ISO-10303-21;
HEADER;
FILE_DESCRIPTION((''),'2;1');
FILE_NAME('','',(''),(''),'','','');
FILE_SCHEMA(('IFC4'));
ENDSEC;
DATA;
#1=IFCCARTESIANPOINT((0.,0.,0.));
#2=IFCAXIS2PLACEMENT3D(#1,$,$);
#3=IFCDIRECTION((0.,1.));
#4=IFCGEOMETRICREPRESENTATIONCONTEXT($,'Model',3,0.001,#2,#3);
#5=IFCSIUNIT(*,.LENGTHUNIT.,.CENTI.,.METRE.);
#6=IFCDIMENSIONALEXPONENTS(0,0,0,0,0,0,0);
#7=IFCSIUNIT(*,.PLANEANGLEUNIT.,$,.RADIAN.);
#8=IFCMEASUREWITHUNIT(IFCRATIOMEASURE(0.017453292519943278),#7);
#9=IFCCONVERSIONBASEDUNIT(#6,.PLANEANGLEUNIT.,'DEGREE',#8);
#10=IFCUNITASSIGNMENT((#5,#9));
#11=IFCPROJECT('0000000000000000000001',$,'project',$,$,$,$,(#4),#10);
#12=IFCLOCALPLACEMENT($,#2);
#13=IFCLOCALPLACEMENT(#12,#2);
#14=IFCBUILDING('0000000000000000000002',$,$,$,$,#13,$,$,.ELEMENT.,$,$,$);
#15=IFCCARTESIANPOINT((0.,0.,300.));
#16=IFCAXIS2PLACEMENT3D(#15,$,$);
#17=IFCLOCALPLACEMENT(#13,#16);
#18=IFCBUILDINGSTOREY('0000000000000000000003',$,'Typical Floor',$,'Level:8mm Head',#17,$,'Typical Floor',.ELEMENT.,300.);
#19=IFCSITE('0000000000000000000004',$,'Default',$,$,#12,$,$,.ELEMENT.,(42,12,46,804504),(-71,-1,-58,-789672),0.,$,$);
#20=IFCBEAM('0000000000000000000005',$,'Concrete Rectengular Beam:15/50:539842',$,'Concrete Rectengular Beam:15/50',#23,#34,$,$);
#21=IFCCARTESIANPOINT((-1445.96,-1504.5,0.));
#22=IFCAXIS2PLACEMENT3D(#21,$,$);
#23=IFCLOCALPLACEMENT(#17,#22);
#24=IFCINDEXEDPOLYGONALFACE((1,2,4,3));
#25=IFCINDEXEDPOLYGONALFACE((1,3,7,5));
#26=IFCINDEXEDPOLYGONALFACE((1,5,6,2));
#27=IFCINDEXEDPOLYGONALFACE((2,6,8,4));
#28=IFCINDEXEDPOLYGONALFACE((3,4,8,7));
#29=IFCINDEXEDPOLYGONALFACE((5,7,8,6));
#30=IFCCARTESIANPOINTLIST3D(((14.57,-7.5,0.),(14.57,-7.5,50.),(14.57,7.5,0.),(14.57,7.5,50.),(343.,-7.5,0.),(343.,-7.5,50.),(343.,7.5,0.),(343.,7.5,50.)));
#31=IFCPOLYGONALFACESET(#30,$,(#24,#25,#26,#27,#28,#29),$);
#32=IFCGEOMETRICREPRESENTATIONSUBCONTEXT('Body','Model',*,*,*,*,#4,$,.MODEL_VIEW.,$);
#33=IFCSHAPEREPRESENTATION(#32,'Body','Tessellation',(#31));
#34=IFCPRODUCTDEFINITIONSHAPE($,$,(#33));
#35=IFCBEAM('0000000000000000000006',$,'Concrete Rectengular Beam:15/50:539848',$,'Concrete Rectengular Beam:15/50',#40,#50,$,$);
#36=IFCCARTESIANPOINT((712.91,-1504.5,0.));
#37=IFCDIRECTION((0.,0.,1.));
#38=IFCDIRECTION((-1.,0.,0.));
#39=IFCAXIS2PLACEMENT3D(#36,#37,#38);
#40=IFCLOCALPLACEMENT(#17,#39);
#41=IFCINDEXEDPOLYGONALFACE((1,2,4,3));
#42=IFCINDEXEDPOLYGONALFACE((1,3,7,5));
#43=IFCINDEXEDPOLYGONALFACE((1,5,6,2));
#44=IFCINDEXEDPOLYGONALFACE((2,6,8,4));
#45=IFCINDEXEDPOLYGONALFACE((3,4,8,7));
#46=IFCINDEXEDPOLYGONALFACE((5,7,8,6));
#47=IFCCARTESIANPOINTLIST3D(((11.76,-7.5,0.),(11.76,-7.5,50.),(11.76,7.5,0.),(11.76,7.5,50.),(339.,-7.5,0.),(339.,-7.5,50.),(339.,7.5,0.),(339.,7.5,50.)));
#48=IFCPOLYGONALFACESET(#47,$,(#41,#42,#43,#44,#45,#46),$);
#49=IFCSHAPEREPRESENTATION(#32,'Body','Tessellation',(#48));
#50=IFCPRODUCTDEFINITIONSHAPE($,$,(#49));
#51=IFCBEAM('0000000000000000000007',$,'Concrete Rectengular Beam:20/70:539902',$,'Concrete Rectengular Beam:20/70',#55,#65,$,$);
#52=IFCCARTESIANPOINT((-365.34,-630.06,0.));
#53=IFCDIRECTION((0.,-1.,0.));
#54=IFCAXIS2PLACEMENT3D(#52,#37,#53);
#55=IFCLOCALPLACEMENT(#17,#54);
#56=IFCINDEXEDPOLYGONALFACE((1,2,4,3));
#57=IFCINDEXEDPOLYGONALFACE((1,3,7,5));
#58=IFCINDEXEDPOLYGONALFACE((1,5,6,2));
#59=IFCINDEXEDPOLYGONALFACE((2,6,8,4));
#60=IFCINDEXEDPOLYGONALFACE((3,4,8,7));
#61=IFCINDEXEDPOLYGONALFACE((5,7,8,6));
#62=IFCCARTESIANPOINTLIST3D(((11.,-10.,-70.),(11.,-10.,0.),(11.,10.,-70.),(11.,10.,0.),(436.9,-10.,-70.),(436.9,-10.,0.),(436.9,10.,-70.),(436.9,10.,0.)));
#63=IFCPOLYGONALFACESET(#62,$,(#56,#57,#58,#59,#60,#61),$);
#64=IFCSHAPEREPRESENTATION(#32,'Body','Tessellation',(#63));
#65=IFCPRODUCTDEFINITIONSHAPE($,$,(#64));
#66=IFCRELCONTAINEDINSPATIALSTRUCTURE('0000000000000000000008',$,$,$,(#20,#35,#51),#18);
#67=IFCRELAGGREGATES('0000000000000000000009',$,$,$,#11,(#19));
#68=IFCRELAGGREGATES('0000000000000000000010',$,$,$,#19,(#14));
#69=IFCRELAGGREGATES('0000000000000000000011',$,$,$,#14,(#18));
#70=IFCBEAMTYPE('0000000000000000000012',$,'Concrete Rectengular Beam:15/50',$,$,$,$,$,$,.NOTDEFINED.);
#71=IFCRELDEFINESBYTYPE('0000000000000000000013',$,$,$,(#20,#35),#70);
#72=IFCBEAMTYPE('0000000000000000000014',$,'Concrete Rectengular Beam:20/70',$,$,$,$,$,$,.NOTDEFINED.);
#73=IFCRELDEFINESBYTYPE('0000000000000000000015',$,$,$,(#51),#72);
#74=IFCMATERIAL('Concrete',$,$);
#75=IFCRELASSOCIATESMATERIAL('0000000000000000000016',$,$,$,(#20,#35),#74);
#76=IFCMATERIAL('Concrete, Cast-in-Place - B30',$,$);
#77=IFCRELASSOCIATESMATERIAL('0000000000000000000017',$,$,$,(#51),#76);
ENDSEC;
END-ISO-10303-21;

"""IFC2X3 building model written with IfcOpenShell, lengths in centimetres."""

from ifc_helpers import new_model, entity, si_unit, converted_unit, direction, frame, frame_2d, origin, place, context, subcontext, project, spatial, rectangle, extrude, material, type_object, element, save


model = new_model("IFC2X3")

# Units and contexts
model_context = context("Model", 3, precision=0.001, world=origin(), true_north=direction((0.0, 1.0)))
body_context = subcontext(model_context, "Body", "Model", "MODEL_VIEW")
ifc_project = project(units=[si_unit("LENGTHUNIT", "METRE", prefix="CENTI"), converted_unit("PLANEANGLEUNIT", "DEGREE", entity("IfcRatioMeasure", 0.017453292519943278), si_unit("PLANEANGLEUNIT", "RADIAN"), dimensions=[0, 0, 0, 0, 0, 0, 0])], contexts=[model_context])

# Site, building, storey
site_placement = place(None, origin())
site = spatial("IfcSite", under=ifc_project, at=site_placement, Name="Default", CompositionType="ELEMENT", RefLatitude=(42, 12, 46, 804504), RefLongitude=(-71, -1, -58, -789672), RefElevation=0.0)
building_placement = place(site_placement, origin())
building = spatial("IfcBuilding", under=site, at=building_placement, CompositionType="ELEMENT")
storey_placement = place(building_placement, frame((0.0, 0.0, 300.0)))
storey = spatial("IfcBuildingStorey", under=building, at=storey_placement, Name="Typical Floor", ObjectType="Level:8mm Head", LongName="Typical Floor", CompositionType="ELEMENT", Elevation=300.0)

# Beams
ifc_material_1 = material(Name="Concrete")
beam_type_1 = type_object("IfcBeamType", Name="Concrete Rectengular Beam:15/50", PredefinedType="NOTDEFINED")
beam_1_placement = place(storey_placement, frame((-1445.96, -1504.5, 0.0)))
element("IfcBeam", 1, at=beam_1_placement, inside=storey, type_object=beam_type_1, material=ifc_material_1, Name="Concrete Rectengular Beam:15/50:539842", ObjectType="Concrete Rectengular Beam:15/50", context=body_context, shape_type="SweptSolid", body=[
    extrude(rectangle(XDim=50.0, YDim=15.0, at=frame_2d((0.0, 0.0), x_axis=(1.0, 0.0))), frame((14.57, 0.0, 25.0), z_axis=(1.0, 0.0, 0.0), x_axis=(0.0, 0.0, -1.0)), (0.0, 0.0, 1.0), 328.43),
])
beam_2_placement = place(storey_placement, frame((712.91, -1504.5, 0.0), z_axis=(0.0, 0.0, 1.0), x_axis=(-1.0, 0.0, 0.0)))
element("IfcBeam", 2, at=beam_2_placement, inside=storey, type_object=beam_type_1, material=ifc_material_1, Name="Concrete Rectengular Beam:15/50:539848", ObjectType="Concrete Rectengular Beam:15/50", context=body_context, shape_type="SweptSolid", body=[
    extrude(rectangle(XDim=50.0, YDim=15.0, at=frame_2d((0.0, 0.0), x_axis=(1.0, 0.0))), frame((11.76, 0.0, 25.0), z_axis=(1.0, 0.0, 0.0), x_axis=(0.0, 0.0, -1.0)), (0.0, 0.0, 1.0), 327.24),
])
ifc_material_2 = material(Name="Concrete, Cast-in-Place - B30")
beam_type_2 = type_object("IfcBeamType", Name="Concrete Rectengular Beam:20/70", PredefinedType="NOTDEFINED")
beam_3_placement = place(storey_placement, frame((-365.34, -630.06, 0.0), z_axis=(0.0, 0.0, 1.0), x_axis=(0.0, -1.0, 0.0)))
element("IfcBeam", 3, at=beam_3_placement, inside=storey, type_object=beam_type_2, material=ifc_material_2, Name="Concrete Rectengular Beam:20/70:539902", ObjectType="Concrete Rectengular Beam:20/70", context=body_context, shape_type="SweptSolid", body=[
    extrude(rectangle(XDim=70.0, YDim=20.0, at=frame_2d((0.0, 0.0), x_axis=(1.0, 0.0))), frame((11.0, 0.0, -35.0), z_axis=(1.0, 0.0, 0.0), x_axis=(0.0, 0.0, -1.0)), (0.0, 0.0, 1.0), 425.9),
])

save(model, "model.ifc")
